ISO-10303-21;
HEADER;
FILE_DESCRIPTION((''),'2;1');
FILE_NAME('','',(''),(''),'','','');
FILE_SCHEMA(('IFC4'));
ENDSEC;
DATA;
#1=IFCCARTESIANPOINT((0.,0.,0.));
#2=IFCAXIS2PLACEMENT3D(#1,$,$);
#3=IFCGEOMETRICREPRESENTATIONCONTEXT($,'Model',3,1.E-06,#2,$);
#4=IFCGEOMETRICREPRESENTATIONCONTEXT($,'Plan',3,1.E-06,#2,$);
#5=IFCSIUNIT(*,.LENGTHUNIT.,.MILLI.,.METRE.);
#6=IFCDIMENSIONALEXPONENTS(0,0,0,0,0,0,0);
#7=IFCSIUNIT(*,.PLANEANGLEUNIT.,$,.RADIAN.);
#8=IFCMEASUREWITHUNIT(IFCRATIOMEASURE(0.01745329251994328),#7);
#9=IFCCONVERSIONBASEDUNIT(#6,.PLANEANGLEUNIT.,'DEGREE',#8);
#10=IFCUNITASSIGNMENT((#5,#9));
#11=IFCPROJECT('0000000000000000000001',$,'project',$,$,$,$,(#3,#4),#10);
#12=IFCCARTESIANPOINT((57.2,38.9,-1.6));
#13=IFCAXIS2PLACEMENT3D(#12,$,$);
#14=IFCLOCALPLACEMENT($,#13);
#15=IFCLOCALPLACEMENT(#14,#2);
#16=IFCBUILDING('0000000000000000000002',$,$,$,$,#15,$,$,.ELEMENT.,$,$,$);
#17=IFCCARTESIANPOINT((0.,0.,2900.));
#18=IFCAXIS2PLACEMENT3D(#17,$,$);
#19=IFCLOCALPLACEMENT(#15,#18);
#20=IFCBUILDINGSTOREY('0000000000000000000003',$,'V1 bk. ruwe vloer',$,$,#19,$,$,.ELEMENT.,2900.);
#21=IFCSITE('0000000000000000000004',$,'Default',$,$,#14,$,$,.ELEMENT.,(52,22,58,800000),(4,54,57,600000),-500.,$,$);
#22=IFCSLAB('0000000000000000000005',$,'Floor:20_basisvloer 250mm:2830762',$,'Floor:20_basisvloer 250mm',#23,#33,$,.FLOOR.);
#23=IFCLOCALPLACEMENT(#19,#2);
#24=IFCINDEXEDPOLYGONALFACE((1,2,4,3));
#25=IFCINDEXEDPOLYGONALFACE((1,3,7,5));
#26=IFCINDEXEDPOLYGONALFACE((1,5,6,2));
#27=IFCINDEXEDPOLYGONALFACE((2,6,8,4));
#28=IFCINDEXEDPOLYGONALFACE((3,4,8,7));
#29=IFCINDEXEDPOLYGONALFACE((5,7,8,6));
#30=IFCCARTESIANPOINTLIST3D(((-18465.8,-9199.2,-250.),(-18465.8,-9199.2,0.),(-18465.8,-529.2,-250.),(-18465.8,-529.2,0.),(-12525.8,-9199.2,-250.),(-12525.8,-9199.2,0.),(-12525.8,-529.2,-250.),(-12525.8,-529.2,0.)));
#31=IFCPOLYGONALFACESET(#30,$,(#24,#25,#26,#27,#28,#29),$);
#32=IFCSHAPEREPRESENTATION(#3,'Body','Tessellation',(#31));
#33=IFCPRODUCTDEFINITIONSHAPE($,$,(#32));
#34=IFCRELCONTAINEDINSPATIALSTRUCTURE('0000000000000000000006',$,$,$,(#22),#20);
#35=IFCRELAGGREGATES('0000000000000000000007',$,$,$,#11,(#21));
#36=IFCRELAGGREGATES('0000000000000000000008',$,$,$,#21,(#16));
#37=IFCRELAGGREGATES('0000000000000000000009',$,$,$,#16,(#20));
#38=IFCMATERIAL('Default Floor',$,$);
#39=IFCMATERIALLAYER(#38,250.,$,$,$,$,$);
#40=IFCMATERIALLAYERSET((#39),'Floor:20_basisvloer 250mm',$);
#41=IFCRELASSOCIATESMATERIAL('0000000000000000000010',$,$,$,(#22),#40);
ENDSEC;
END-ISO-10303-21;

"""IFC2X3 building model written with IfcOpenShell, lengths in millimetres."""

from ifc_helpers import new_model, entity, si_unit, converted_unit, frame, origin, origin_2d_with_axis, place, context, project, spatial, rectangle, extrude, material, layer, layer_set, layer_usage, element, save


model = new_model("IFC2X3")

# Units and contexts
model_context = context("Model", 3, precision=1e-06, world=origin())
plan_context = context("Plan", 3, precision=1e-06, world=origin())
ifc_project = project(units=[si_unit("LENGTHUNIT", "METRE", prefix="MILLI"), converted_unit("PLANEANGLEUNIT", "DEGREE", entity("IfcRatioMeasure", 0.01745329251994328), si_unit("PLANEANGLEUNIT", "RADIAN"), dimensions=[0, 0, 0, 0, 0, 0, 0])], contexts=[model_context, plan_context])

# Site, building, storey
site_placement = place(None, frame((57.2, 38.9, -1.6)))
site = spatial("IfcSite", under=ifc_project, at=site_placement, Name="Default", CompositionType="ELEMENT", RefLatitude=(52, 22, 58, 800000), RefLongitude=(4, 54, 57, 600000), RefElevation=-500.0)
building_placement = place(site_placement, origin())
building = spatial("IfcBuilding", under=site, at=building_placement, CompositionType="ELEMENT")
storey_placement = place(building_placement, frame((0.0, 0.0, 2900.0)))
storey = spatial("IfcBuildingStorey", under=building, at=storey_placement, Name="V1 bk. ruwe vloer", CompositionType="ELEMENT", Elevation=2900.0)

# Slab
ifc_material = material(Name="Default Floor")
ifc_layer = layer(ifc_material, 250.0)
ifc_layer_set = layer_set([ifc_layer], Name="Floor:20_basisvloer 250mm")
ifc_layer_usage_1 = layer_usage(ifc_layer_set, "AXIS3", "POSITIVE", 0.0)
slab_1_placement = place(storey_placement, frame((-18465.8, -9199.2, -250.0)))
element("IfcSlab", 1, at=slab_1_placement, inside=storey, material=ifc_layer_usage_1, Name="Floor:20_basisvloer 250mm:2830762", ObjectType="Floor:20_basisvloer 250mm", PredefinedType="FLOOR", context=model_context, shape_type="SweptSolid", body=[
    extrude(rectangle(XDim=5940.0, YDim=8670.0, at=origin_2d_with_axis()), frame((2970.0, 4335.0, 250.0), z_axis=(0.0, 0.0, -1.0), x_axis=(-1.0, 0.0, 0.0)), (0.0, 0.0, 1.0), 250.0),
])

save(model, "model.ifc")
